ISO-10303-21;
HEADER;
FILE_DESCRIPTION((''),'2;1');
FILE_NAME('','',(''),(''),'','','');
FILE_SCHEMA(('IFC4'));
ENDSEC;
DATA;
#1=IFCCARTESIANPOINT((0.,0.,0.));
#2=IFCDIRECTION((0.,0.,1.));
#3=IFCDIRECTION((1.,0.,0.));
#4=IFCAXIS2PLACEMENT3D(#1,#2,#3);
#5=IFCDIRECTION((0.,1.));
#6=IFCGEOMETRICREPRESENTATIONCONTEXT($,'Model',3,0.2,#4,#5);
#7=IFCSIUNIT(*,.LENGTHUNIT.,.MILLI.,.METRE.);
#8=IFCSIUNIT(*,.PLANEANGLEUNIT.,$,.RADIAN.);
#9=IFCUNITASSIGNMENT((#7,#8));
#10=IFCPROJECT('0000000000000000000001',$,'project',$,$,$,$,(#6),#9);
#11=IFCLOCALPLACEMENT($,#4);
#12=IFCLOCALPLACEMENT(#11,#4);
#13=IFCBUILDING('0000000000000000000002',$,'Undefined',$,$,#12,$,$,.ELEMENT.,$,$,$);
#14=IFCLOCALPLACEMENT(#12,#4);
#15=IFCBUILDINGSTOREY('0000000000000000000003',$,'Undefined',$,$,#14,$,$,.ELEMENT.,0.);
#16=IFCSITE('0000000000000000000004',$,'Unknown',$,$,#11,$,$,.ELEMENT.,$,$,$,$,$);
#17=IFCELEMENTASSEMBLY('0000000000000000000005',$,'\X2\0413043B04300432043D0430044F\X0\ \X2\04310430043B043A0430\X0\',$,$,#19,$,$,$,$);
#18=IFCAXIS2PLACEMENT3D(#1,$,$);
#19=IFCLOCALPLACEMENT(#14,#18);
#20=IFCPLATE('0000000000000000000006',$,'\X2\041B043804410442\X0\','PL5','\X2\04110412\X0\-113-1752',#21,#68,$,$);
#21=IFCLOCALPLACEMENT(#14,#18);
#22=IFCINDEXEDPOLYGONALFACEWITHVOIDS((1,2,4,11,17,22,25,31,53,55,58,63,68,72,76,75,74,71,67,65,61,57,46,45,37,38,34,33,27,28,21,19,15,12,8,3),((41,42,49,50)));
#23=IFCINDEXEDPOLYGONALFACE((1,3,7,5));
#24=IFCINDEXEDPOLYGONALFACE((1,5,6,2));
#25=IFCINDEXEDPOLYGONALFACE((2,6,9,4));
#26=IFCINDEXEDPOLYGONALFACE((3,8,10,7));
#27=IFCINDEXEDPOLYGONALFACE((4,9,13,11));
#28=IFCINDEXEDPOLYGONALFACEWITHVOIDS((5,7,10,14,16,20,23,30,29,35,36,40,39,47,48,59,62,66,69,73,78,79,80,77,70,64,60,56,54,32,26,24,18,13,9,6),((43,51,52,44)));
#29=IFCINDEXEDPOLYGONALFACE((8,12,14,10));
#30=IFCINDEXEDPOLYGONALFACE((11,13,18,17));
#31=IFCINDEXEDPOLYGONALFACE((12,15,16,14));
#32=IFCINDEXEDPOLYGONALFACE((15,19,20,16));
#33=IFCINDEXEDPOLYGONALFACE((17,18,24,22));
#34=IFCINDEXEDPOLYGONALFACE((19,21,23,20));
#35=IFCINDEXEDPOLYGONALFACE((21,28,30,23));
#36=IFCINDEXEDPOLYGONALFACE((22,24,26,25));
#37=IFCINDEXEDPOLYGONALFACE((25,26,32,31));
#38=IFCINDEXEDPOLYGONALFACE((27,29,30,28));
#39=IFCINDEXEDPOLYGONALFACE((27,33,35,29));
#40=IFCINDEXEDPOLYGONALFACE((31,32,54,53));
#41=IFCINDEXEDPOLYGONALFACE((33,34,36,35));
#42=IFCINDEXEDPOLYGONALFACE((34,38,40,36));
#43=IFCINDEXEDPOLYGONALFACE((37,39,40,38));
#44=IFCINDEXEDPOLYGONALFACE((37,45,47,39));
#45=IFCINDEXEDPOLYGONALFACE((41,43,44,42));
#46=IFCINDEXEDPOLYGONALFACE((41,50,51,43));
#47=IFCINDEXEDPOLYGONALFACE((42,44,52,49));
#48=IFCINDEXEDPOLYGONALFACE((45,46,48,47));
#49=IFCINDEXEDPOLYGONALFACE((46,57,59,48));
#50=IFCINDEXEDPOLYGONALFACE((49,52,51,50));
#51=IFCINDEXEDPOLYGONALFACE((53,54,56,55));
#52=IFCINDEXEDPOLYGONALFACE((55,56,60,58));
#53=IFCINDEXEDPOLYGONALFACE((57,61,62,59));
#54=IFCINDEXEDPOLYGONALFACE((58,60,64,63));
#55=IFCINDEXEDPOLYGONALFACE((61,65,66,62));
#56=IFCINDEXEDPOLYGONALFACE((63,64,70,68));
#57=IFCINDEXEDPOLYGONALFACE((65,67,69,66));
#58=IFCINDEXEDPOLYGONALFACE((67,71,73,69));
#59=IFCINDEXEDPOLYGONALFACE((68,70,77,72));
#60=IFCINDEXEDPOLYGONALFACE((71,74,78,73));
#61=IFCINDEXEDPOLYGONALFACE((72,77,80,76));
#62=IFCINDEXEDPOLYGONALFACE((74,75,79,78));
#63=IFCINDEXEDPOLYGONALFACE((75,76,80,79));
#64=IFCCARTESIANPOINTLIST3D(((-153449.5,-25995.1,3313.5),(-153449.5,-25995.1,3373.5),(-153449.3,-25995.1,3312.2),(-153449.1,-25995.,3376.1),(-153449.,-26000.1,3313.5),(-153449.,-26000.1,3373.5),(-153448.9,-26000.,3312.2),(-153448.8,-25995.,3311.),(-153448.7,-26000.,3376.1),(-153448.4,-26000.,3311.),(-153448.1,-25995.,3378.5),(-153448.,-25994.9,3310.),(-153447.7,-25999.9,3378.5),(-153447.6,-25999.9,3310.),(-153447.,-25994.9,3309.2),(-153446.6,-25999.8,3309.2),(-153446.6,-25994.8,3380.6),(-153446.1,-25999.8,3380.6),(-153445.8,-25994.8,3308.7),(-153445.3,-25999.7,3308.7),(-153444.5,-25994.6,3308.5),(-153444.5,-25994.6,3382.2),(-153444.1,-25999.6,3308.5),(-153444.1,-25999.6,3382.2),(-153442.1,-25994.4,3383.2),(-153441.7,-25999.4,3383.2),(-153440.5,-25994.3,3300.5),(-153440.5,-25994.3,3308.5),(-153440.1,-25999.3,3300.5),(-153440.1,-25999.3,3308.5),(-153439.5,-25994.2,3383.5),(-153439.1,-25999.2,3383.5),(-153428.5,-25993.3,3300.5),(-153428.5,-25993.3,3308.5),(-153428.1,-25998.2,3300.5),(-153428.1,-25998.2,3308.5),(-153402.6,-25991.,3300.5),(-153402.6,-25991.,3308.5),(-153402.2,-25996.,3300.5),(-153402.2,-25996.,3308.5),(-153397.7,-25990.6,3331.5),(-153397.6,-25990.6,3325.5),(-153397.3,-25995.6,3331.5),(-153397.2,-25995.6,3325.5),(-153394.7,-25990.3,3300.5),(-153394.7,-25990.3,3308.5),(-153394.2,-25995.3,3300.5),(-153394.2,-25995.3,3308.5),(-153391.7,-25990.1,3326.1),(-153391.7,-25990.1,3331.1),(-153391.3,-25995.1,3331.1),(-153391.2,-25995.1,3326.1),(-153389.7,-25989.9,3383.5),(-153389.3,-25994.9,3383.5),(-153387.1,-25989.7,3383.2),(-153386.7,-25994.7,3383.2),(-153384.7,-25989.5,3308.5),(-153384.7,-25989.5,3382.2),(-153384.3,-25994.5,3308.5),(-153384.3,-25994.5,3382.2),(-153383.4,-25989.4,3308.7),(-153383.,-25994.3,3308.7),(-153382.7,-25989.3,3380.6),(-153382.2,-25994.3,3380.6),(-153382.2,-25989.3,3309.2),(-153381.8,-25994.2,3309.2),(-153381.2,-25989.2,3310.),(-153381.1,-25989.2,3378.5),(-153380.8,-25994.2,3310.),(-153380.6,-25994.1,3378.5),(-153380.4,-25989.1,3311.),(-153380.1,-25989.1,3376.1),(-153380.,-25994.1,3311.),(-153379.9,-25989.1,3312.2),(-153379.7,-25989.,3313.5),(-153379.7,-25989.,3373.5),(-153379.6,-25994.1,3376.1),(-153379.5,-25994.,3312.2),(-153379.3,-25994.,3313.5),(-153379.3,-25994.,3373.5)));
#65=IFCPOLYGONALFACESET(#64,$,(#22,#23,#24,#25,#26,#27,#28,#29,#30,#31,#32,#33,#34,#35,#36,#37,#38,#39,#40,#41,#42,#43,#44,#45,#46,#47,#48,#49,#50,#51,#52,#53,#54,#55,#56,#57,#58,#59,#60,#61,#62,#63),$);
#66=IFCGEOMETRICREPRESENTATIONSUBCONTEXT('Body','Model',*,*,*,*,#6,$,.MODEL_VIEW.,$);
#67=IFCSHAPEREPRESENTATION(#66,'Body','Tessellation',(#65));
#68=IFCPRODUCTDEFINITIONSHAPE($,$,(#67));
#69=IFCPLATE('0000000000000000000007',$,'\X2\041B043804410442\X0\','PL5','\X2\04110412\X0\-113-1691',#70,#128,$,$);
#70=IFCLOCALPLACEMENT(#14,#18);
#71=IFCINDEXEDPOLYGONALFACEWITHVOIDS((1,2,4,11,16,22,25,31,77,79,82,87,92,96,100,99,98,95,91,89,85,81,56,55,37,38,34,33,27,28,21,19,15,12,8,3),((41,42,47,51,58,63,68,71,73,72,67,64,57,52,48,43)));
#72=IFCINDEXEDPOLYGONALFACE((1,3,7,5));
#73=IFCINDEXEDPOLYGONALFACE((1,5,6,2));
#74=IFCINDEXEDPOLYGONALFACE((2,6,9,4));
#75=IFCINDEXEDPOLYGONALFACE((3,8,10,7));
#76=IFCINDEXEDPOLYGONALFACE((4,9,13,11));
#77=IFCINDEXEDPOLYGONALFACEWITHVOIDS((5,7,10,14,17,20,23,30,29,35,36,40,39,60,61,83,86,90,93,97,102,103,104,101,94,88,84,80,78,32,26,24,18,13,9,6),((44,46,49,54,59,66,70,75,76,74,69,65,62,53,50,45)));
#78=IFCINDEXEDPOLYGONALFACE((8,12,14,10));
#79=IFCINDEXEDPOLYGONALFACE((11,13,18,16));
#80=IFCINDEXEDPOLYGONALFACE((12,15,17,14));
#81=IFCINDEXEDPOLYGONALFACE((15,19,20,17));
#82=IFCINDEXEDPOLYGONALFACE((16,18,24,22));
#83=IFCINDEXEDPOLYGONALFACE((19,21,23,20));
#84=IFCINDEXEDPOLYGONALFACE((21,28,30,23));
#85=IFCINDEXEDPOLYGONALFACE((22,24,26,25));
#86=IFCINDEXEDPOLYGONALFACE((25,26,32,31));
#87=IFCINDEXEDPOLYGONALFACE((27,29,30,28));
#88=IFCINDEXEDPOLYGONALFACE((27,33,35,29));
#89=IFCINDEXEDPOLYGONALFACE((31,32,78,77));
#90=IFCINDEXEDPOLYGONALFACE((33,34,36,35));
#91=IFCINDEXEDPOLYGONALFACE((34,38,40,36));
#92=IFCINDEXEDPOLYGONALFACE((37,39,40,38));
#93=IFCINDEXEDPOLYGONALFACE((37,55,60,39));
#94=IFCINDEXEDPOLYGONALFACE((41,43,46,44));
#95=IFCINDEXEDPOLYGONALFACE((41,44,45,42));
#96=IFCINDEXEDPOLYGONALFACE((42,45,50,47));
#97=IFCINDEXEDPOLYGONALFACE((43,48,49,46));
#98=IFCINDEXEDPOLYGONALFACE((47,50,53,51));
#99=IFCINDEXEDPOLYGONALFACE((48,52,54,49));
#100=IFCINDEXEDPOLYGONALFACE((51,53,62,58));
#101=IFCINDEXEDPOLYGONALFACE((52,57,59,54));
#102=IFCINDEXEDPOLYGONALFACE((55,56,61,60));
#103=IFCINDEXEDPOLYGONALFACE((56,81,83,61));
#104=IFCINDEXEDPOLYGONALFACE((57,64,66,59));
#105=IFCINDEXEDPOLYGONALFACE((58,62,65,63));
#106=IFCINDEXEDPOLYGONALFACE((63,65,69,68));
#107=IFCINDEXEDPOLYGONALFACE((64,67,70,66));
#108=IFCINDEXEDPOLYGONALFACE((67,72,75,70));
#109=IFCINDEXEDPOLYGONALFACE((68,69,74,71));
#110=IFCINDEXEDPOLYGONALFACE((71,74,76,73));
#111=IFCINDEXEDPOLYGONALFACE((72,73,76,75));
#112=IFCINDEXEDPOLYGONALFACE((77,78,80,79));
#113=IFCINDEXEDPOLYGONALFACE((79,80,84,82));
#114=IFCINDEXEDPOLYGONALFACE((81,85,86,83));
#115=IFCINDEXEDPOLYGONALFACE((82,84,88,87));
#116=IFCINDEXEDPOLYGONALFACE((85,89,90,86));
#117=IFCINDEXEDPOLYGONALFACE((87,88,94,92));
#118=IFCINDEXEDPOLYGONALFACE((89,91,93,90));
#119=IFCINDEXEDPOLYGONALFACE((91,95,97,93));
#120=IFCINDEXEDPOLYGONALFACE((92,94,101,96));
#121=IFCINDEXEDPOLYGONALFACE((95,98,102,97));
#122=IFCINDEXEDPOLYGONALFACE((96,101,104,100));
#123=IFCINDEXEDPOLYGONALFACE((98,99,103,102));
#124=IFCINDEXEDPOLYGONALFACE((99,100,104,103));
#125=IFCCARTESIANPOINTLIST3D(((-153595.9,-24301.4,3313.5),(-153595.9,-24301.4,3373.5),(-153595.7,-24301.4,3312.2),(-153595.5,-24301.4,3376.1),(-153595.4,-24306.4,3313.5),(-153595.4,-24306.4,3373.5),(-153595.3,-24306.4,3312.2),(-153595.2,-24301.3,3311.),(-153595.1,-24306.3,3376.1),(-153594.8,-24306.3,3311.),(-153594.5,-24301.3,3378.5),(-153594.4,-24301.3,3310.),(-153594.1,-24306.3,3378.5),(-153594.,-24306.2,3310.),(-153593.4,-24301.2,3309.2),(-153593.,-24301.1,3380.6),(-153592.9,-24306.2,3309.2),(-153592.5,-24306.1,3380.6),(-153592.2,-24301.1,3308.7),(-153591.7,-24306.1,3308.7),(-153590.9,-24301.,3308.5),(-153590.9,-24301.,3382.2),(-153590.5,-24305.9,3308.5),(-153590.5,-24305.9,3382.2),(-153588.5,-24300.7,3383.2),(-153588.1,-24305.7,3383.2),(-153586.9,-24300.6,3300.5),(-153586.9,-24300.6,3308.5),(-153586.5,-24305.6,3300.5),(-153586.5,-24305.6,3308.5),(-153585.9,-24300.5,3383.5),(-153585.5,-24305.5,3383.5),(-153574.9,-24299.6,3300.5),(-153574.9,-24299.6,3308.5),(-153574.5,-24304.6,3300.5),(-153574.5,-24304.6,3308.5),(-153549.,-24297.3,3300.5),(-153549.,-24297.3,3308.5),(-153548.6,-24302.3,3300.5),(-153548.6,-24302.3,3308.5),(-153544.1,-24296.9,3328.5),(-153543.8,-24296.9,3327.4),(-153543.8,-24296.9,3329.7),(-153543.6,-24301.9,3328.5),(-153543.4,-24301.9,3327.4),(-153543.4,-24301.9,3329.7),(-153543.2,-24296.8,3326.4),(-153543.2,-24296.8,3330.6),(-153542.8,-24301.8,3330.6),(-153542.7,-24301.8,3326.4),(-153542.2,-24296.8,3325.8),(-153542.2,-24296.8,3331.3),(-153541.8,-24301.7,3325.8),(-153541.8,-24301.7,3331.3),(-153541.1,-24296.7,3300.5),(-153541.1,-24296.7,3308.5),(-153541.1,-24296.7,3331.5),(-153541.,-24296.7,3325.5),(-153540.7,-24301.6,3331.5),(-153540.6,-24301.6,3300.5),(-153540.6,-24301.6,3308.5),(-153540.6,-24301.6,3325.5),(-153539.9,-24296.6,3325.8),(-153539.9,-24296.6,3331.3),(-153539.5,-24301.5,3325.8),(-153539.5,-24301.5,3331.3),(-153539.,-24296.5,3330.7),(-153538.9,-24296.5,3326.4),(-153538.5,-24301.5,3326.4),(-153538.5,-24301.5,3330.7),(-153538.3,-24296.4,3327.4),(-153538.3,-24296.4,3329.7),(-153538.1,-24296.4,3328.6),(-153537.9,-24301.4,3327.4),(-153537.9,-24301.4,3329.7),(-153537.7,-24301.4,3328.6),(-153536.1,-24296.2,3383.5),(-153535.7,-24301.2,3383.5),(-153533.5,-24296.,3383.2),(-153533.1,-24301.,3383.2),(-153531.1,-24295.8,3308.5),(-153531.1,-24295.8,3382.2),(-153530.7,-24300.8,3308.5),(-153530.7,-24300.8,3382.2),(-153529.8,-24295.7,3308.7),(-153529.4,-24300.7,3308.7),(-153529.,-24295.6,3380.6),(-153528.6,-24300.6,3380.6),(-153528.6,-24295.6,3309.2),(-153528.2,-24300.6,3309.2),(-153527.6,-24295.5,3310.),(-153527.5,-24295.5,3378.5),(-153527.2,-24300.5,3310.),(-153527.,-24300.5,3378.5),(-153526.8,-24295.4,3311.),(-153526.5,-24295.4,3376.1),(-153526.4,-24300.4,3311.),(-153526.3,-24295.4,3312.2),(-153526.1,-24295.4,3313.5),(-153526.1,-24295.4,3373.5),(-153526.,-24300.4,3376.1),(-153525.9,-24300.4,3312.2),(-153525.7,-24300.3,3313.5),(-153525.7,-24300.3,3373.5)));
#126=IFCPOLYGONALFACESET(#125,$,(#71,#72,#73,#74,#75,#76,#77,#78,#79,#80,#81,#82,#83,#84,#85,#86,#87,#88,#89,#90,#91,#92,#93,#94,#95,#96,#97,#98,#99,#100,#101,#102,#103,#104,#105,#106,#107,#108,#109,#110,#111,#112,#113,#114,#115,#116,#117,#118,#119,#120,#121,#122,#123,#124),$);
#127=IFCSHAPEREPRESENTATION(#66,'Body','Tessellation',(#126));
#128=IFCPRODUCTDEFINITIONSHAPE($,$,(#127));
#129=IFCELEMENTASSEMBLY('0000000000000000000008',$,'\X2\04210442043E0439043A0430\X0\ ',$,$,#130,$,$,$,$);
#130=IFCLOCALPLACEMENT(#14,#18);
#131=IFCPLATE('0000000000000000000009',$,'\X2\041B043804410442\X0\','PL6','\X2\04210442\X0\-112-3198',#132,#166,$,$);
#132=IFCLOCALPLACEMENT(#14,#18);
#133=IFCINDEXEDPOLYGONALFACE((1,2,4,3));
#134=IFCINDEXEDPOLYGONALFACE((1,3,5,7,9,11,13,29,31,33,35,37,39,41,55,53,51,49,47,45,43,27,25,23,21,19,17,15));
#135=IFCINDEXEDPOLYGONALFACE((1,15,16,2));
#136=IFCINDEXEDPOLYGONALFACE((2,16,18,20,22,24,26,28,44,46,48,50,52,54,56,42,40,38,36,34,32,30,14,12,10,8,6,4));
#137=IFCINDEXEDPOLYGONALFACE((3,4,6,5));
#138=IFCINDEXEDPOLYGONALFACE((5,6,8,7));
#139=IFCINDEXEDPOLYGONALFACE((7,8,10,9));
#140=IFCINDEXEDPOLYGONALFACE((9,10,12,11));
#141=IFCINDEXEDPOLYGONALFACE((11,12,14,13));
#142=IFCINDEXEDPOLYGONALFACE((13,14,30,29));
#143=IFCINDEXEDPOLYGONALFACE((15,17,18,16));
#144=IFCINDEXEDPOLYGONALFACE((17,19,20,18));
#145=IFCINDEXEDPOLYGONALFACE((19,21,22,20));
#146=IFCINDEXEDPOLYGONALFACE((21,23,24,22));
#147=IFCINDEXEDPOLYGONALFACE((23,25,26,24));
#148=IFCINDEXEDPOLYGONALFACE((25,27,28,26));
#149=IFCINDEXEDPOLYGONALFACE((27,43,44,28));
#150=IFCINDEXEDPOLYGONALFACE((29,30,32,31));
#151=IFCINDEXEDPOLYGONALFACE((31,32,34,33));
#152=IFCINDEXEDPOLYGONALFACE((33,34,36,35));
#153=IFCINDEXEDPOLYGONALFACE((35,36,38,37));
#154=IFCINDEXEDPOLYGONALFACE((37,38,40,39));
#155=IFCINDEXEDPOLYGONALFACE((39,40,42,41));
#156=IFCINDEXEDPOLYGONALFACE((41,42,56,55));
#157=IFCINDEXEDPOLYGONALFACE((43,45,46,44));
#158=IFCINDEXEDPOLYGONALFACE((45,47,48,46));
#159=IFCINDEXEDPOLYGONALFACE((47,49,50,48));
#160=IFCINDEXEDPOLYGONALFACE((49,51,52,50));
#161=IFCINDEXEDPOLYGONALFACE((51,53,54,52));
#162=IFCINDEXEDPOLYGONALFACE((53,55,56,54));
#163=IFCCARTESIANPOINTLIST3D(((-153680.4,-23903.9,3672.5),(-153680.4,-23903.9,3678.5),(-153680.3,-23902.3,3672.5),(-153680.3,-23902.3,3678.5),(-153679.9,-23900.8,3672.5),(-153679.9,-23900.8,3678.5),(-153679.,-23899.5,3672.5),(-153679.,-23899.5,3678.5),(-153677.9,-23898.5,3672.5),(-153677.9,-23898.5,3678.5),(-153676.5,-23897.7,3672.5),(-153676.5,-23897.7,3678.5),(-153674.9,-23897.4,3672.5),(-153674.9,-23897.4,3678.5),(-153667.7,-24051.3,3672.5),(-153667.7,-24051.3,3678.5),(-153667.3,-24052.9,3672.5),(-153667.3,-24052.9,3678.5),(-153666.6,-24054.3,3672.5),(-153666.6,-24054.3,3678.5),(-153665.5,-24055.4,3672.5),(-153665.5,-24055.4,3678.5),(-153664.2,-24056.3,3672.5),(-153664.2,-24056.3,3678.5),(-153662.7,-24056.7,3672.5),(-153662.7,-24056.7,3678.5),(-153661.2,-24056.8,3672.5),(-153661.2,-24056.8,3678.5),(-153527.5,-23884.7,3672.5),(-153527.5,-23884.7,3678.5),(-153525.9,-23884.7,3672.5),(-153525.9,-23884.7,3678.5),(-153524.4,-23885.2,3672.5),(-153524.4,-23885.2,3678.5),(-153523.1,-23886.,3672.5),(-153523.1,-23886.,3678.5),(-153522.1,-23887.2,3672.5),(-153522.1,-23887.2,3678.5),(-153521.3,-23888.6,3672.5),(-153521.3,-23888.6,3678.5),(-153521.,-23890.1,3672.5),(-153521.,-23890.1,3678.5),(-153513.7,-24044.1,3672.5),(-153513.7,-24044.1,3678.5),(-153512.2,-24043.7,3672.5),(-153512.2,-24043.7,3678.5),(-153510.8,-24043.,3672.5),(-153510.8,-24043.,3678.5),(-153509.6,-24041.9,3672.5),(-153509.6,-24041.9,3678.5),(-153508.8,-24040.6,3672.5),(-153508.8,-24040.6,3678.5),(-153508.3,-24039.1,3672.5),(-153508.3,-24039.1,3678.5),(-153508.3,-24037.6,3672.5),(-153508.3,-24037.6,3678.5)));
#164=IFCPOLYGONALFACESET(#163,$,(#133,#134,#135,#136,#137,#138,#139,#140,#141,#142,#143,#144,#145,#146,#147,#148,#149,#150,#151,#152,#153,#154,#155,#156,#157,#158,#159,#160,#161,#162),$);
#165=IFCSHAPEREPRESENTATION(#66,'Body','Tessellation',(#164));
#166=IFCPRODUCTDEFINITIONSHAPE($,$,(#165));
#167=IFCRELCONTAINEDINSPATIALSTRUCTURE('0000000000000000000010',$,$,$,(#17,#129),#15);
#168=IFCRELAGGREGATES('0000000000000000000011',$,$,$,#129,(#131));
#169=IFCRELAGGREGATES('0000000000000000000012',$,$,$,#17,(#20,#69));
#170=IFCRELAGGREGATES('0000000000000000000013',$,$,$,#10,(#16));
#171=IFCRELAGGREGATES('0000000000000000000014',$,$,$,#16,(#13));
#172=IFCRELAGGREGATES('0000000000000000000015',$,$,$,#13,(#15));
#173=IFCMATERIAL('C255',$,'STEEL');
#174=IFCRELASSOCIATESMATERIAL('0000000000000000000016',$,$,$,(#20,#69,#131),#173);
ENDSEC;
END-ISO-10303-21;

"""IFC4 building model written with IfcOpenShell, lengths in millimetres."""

from ifc_helpers import new_model, si_unit, direction, frame, origin_with_axes, place, context, subcontext, project, spatial, line, arc, indexed_curve, outline, extrude, material, element, aggregate, save


model = new_model("IFC4")

# Units and contexts
model_context = context("Model", 3, precision=0.2, world=origin_with_axes(), true_north=direction((0.0, 1.0)))
body_context = subcontext(model_context, "Body", "Model", "MODEL_VIEW")
ifc_project = project(units=[si_unit("LENGTHUNIT", "METRE", prefix="MILLI"), si_unit("PLANEANGLEUNIT", "RADIAN")], contexts=[model_context])

# Site, building, storey
site_placement = place(None, origin_with_axes())
site = spatial("IfcSite", under=ifc_project, at=site_placement, Name="Unknown", CompositionType="ELEMENT")
building_placement = place(site_placement, origin_with_axes())
building = spatial("IfcBuilding", under=site, at=building_placement, Name="Undefined", CompositionType="ELEMENT")
storey_placement = place(building_placement, origin_with_axes())
storey = spatial("IfcBuildingStorey", under=building, at=storey_placement, Name="Undefined", CompositionType="ELEMENT", Elevation=0.0)

# Shared definitions
ifc_material_1 = material(Name="C255", Category="STEEL")

# Element assembly, plates, voiding features
assembly_1_placement = place(storey_placement, frame((-153409.2, -26112.7, 3248.5), z_axis=(-0.996285, -0.086114, -0.000024), x_axis=(-0.086114, 0.996285, 0.0)))
assembly_1 = element("IfcElementAssembly", 1, at=assembly_1_placement, inside=storey, Name="Главная балка")
plate_1_placement = place(assembly_1_placement, frame((118.2, -135.0, -40.0), z_axis=(-1.0, -0.000054, 0.0), x_axis=(0.0, 0.000054, 1.0)))
plate_1 = element("IfcPlate", 2, at=plate_1_placement, material=ifc_material_1, Name="Лист", Description="PL5", ObjectType="БВ-113-1752", context=body_context, shape_type="SolidModel", body=[
    extrude(outline(indexed_curve([(0.0, 10.0), (2.9, 2.9), (10.0, 0.0), (60.0, 0.0), (67.1, 2.9), (70.0, 10.0), (70.0, 70.0), (68.5, 73.5), (65.0, 75.0), (61.0, 75.0), (61.0, 83.0), (49.0, 83.0), (49.0, 75.0), (23.0, 75.0), (23.0, 83.0), (15.0, 83.0), (15.0, 75.0), (5.0, 75.0), (1.5, 73.5), (0.0, 70.0)], segments=[arc(1, 2, 3), line(3, 4), arc(4, 5, 6), line(6, 7), arc(7, 8, 9), line(9, 10, 11, 12, 13, 14, 15, 16, 17, 18), arc(18, 19, 20), line(20, 1)])), frame((0.0, 0.0, 2.5), z_axis=(0.0, 0.0, 1.0), x_axis=(1.0, 0.0, 0.0)), (0.0, 0.0, -1.0), 5.0),
])
voiding_feature_1_placement = place(plate_1_placement, frame((15.0, 55.0, 10.0), z_axis=(0.007997, -0.999968, -0.000026), x_axis=(0.0, 0.000026, -1.0)))
element("IfcVoidingFeature", 3, at=voiding_feature_1_placement, cuts=plate_1, Name="Балка", ObjectType="(?)", PredefinedType="HOLE", context=body_context, shape_type="SolidModel", body=[
    extrude(outline(indexed_curve([(2.5, -3.0), (3.0, 3.0), (-3.0, 3.0), (-2.5, -3.0)], segments=[line(1, 2, 3, 4, 1)])), frame((0.0, 0.0, 0.0), z_axis=(-1.0, 0.0, 0.0), x_axis=(0.0, 0.0, 1.0)), (0.0, 0.0, -1.0), 20.0),
])
plate_2_placement = place(assembly_1_placement, frame((1818.2, -135.0, -40.0), z_axis=(-1.0, -0.000054, 0.0), x_axis=(0.0, 0.000054, 1.0)))
plate_2 = element("IfcPlate", 4, at=plate_2_placement, material=ifc_material_1, Name="Лист", Description="PL5", ObjectType="БВ-113-1691", context=body_context, shape_type="SolidModel", body=[
    extrude(outline(indexed_curve([(0.0, 10.0), (2.9, 2.9), (10.0, 0.0), (60.0, 0.0), (67.1, 2.9), (70.0, 10.0), (70.0, 70.0), (68.5, 73.5), (65.0, 75.0), (61.0, 75.0), (61.0, 83.0), (49.0, 83.0), (49.0, 75.0), (23.0, 75.0), (23.0, 83.0), (15.0, 83.0), (15.0, 75.0), (5.0, 75.0), (1.5, 73.5), (0.0, 70.0)], segments=[arc(1, 2, 3), line(3, 4), arc(4, 5, 6), line(6, 7), arc(7, 8, 9), line(9, 10, 11, 12, 13, 14, 15, 16, 17, 18), arc(18, 19, 20), line(20, 1)])), frame((0.0, 0.0, 2.5), z_axis=(0.0, 0.0, 1.0), x_axis=(1.0, 0.0, 0.0)), (0.0, 0.0, -1.0), 5.0),
])
voiding_feature_2_placement = place(plate_2_placement, frame((15.0, 55.0, 10.0), z_axis=(0.007997, -0.999968, -0.000026), x_axis=(0.0, 0.000026, -1.0)))
element("IfcVoidingFeature", 5, at=voiding_feature_2_placement, cuts=plate_2, Name="Балка", ObjectType="(?)", PredefinedType="HOLE", context=body_context, shape_type="SolidModel", body=[
    extrude(outline(indexed_curve([(3.0, 0.0), (2.8, 1.1), (2.1, 2.1), (1.1, 2.8), (0.0, 3.0), (-1.1, 2.8), (-2.1, 2.1), (-2.8, 1.1), (-3.0, 0.0), (-2.8, -1.1), (-2.1, -2.1), (-1.1, -2.8), (0.0, -3.0), (1.1, -2.8), (2.1, -2.1), (2.8, -1.1)], segments=[line(1, 2, 3, 4, 5, 6, 7, 8, 9, 10, 11, 12, 13, 14, 15, 16, 1)])), frame((0.0, 0.0, 0.0), z_axis=(-1.0, 0.0, 0.0), x_axis=(0.0, 0.0, 1.0)), (0.0, 0.0, -1.0), 20.0),
])

# Element assembly, plate
assembly_2_placement = place(storey_placement, frame((-153594.3, -23970.7, 3672.5), z_axis=(-0.086114, 0.996285, 0.0), x_axis=(0.0, 0.0, 1.0)))
assembly_2 = element("IfcElementAssembly", 6, at=assembly_2_placement, inside=storey, Name="Стойка ")
plate_3_placement = place(assembly_2_placement, frame((3.0, 80.0, -80.0), z_axis=(1.0, 0.0, 0.0), x_axis=(0.0, 0.0, 1.0)))
plate_3 = element("IfcPlate", 7, at=plate_3_placement, material=ifc_material_1, Name="Лист", Description="PL6", ObjectType="Ст-112-3198", context=body_context, shape_type="SolidModel", body=[
    extrude(outline(indexed_curve([(0.0, 6.0), (1.8, 1.8), (6.0, 0.0), (154.0, 0.0), (158.2, 1.8), (160.0, 6.0), (160.0, 154.0), (158.2, 158.2), (154.0, 160.0), (6.0, 160.0), (1.8, 158.2), (0.0, 154.0)], segments=[arc(1, 2, 3), line(3, 4), arc(4, 5, 6), line(6, 7), arc(7, 8, 9), line(9, 10), arc(10, 11, 12), line(12, 1)])), frame((0.0, 0.0, 3.0), z_axis=(0.0, 0.0, 1.0), x_axis=(1.0, 0.0, 0.0)), (0.0, 0.0, -1.0), 6.0),
])
aggregate(assembly_2, [plate_3])

aggregate(assembly_1, [plate_1, plate_2])

save(model, "model.ifc")
